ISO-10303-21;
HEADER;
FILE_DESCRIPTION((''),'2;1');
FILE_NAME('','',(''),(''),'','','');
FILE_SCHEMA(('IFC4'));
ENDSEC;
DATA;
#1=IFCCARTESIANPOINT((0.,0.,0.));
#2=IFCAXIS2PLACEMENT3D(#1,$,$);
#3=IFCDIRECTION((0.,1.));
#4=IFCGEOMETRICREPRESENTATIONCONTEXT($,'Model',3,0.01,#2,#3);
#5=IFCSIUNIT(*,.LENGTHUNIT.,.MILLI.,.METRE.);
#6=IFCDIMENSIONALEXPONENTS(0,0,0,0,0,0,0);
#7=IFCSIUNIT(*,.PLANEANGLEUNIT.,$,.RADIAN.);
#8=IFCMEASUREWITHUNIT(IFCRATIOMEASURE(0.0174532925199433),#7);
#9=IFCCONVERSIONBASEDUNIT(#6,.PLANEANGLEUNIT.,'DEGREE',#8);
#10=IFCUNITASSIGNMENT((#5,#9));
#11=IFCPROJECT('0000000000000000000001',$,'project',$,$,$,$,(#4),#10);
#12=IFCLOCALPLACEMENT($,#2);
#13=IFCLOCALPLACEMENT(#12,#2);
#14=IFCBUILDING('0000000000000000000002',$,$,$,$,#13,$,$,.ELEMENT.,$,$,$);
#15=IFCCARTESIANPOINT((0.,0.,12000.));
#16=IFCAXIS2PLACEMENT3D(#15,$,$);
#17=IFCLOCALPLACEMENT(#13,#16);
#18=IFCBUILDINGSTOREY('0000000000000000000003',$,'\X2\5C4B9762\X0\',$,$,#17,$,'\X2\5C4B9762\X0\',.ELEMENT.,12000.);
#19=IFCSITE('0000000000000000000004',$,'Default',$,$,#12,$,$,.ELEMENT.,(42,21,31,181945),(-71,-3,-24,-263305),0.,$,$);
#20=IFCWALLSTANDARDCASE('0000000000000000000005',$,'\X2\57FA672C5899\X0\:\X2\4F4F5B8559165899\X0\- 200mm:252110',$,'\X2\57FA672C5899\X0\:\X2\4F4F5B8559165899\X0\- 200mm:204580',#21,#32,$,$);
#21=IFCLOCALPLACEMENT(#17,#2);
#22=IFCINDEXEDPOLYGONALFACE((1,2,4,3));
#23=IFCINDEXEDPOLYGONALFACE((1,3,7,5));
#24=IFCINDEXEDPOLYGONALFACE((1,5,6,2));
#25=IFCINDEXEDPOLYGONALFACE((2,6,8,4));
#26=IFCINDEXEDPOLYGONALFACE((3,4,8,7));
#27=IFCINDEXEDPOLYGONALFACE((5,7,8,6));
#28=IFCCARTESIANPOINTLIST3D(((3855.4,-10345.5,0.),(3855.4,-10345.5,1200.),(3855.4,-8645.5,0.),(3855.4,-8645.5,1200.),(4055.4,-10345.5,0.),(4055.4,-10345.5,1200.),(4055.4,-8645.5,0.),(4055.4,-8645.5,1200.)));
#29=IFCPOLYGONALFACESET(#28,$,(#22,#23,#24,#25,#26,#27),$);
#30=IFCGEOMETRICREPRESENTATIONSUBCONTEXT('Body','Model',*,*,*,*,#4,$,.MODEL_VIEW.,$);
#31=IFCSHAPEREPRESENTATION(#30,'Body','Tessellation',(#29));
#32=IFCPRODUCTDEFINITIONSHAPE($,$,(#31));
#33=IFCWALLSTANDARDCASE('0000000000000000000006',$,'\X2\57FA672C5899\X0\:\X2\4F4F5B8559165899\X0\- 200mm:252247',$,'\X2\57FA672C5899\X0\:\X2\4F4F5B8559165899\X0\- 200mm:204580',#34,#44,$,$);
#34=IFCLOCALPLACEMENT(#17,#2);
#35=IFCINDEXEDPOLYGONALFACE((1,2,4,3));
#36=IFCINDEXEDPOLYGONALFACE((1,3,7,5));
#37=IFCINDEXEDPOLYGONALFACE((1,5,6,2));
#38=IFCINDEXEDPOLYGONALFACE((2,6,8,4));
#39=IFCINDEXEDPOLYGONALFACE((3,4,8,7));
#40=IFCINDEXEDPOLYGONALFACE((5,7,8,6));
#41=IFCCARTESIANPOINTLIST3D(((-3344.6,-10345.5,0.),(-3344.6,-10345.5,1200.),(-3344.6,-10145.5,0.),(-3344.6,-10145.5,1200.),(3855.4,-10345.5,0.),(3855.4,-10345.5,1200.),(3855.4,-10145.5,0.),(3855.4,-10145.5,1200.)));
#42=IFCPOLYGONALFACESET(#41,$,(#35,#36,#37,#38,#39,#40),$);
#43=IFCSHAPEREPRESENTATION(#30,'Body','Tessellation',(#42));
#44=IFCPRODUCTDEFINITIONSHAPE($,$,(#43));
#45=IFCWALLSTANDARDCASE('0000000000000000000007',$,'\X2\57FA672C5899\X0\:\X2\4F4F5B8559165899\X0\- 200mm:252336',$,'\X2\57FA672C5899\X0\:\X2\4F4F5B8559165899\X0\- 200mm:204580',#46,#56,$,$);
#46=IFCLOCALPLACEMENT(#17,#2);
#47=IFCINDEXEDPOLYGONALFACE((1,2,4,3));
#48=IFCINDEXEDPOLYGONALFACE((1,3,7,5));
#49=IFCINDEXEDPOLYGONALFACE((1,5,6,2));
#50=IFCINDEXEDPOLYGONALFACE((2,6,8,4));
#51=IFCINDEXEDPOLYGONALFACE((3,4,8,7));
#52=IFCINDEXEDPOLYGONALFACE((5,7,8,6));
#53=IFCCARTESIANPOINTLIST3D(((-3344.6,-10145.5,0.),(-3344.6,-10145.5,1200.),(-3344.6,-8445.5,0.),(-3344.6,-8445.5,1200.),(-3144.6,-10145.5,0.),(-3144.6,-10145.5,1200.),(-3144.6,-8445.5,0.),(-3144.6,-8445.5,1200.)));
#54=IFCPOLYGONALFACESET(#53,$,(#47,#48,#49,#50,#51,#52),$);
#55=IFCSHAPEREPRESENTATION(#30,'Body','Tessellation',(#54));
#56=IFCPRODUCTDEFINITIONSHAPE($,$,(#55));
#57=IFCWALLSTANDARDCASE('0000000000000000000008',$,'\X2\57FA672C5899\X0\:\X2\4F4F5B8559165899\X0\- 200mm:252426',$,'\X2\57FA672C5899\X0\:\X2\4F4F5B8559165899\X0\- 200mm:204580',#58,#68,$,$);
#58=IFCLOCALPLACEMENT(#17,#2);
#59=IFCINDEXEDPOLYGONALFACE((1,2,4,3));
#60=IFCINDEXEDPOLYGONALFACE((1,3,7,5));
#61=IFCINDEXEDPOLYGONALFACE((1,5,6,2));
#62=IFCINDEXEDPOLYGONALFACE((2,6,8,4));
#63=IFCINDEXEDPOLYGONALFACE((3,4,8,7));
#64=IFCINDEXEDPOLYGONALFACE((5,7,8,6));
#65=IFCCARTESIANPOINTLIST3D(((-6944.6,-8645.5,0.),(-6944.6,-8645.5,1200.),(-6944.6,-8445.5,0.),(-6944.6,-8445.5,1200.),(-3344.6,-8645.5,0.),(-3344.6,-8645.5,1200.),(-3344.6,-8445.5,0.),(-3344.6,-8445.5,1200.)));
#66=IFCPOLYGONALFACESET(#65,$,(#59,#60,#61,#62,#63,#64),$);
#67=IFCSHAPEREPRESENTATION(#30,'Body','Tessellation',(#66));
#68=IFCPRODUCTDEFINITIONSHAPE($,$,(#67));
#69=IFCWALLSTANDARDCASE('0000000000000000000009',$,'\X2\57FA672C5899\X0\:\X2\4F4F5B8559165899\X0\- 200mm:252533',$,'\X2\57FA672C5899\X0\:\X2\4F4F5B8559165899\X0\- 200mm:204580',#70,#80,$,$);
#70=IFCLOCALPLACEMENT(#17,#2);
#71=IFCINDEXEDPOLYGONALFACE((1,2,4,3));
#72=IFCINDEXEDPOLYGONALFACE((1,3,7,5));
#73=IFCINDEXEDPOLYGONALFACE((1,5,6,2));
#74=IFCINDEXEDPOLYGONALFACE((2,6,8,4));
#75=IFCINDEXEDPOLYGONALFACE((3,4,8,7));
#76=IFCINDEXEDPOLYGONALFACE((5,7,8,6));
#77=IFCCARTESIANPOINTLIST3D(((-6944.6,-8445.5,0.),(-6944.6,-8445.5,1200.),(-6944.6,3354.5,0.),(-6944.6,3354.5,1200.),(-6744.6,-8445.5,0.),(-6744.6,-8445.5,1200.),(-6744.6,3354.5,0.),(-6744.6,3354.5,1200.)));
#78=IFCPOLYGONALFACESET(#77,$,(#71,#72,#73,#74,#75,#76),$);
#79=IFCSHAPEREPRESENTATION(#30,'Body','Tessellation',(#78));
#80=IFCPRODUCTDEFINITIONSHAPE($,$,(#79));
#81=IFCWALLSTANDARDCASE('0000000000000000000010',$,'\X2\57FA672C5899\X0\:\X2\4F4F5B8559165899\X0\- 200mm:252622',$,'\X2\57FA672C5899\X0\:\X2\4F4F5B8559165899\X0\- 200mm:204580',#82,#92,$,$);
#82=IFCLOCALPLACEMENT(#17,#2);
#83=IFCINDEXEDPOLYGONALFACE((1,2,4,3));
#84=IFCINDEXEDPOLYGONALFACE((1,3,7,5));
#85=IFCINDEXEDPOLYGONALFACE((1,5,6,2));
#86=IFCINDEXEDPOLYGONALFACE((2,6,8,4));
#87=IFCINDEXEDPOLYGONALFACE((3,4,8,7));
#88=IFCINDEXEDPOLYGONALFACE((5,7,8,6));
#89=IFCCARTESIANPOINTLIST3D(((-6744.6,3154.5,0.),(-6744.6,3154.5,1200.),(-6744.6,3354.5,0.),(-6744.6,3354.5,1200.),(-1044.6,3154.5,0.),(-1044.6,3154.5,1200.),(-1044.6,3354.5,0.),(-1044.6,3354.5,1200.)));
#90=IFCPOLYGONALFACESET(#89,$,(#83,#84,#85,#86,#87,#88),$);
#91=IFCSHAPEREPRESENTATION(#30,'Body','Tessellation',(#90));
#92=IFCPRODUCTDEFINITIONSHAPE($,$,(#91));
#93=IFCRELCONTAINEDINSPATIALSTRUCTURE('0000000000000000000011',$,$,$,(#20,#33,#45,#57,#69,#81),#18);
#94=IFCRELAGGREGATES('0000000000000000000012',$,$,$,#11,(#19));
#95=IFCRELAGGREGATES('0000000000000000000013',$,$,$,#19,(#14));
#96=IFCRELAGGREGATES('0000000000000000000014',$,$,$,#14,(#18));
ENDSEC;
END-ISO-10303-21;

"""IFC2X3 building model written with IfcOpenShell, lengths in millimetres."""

from ifc_helpers import new_model, entity, si_unit, converted_unit, direction, frame, frame_2d, origin, place, context, subcontext, project, spatial, rectangle, extrude, element, save


model = new_model("IFC2X3")

# Units and contexts
model_context = context("Model", 3, precision=0.01, world=origin(), true_north=direction((0.0, 1.0)))
body_context = subcontext(model_context, "Body", "Model", "MODEL_VIEW")
ifc_project = project(units=[si_unit("LENGTHUNIT", "METRE", prefix="MILLI"), converted_unit("PLANEANGLEUNIT", "DEGREE", entity("IfcRatioMeasure", 0.0174532925199433), si_unit("PLANEANGLEUNIT", "RADIAN"), dimensions=[0, 0, 0, 0, 0, 0, 0])], contexts=[model_context])

# Site, building, storey
site_placement = place(None, origin())
site = spatial("IfcSite", under=ifc_project, at=site_placement, Name="Default", CompositionType="ELEMENT", RefLatitude=(42, 21, 31, 181945), RefLongitude=(-71, -3, -24, -263305), RefElevation=0.0)
building_placement = place(site_placement, origin())
building = spatial("IfcBuilding", under=site, at=building_placement, CompositionType="ELEMENT")
storey_placement = place(building_placement, frame((0.0, 0.0, 12000.0)))
storey = spatial("IfcBuildingStorey", under=building, at=storey_placement, Name="屋面", LongName="屋面", CompositionType="ELEMENT", Elevation=12000.0)

# Walls
wall_1_placement = place(storey_placement, frame((3955.4, -8645.5, 0.0), z_axis=(0.0, 0.0, 1.0), x_axis=(0.0, -1.0, 0.0)))
element("IfcWallStandardCase", 1, at=wall_1_placement, inside=storey, Name="基本墙:住宅外墙- 200mm:252110", ObjectType="基本墙:住宅外墙- 200mm:204580", context=body_context, shape_type="SweptSolid", body=[
    extrude(rectangle(XDim=1700.0, YDim=200.0, at=frame_2d((850.0, 0.0), x_axis=(-1.0, 0.0))), origin(), (0.0, 0.0, 1.0), 1200.0),
])
wall_2_placement = place(storey_placement, frame((3855.4, -10245.5, 0.0), z_axis=(0.0, 0.0, 1.0), x_axis=(-1.0, 0.0, 0.0)))
element("IfcWallStandardCase", 2, at=wall_2_placement, inside=storey, Name="基本墙:住宅外墙- 200mm:252247", ObjectType="基本墙:住宅外墙- 200mm:204580", context=body_context, shape_type="SweptSolid", body=[
    extrude(rectangle(XDim=7200.0, YDim=200.0, at=frame_2d((3600.0, 0.0), x_axis=(-1.0, 0.0))), origin(), (0.0, 0.0, 1.0), 1200.0),
])
wall_3_placement = place(storey_placement, frame((-3244.6, -10145.5, 0.0), z_axis=(0.0, 0.0, 1.0), x_axis=(0.0, 1.0, 0.0)))
element("IfcWallStandardCase", 3, at=wall_3_placement, inside=storey, Name="基本墙:住宅外墙- 200mm:252336", ObjectType="基本墙:住宅外墙- 200mm:204580", context=body_context, shape_type="SweptSolid", body=[
    extrude(rectangle(XDim=1700.0, YDim=200.0, at=frame_2d((850.0, 0.0), x_axis=(-1.0, 0.0))), origin(), (0.0, 0.0, 1.0), 1200.0),
])
wall_4_placement = place(storey_placement, frame((-3344.6, -8545.5, 0.0), z_axis=(0.0, 0.0, 1.0), x_axis=(-1.0, 0.0, 0.0)))
element("IfcWallStandardCase", 4, at=wall_4_placement, inside=storey, Name="基本墙:住宅外墙- 200mm:252426", ObjectType="基本墙:住宅外墙- 200mm:204580", context=body_context, shape_type="SweptSolid", body=[
    extrude(rectangle(XDim=3600.0, YDim=200.0, at=frame_2d((1800.0, 0.0), x_axis=(-1.0, 0.0))), origin(), (0.0, 0.0, 1.0), 1200.0),
])
wall_5_placement = place(storey_placement, frame((-6844.6, -8445.5, 0.0), z_axis=(0.0, 0.0, 1.0), x_axis=(0.0, 1.0, 0.0)))
element("IfcWallStandardCase", 5, at=wall_5_placement, inside=storey, Name="基本墙:住宅外墙- 200mm:252533", ObjectType="基本墙:住宅外墙- 200mm:204580", context=body_context, shape_type="SweptSolid", body=[
    extrude(rectangle(XDim=11800.0, YDim=200.0, at=frame_2d((5900.0, 0.0), x_axis=(-1.0, 0.0))), origin(), (0.0, 0.0, 1.0), 1200.0),
])
wall_6_placement = place(storey_placement, frame((-6744.6, 3254.5, 0.0)))
element("IfcWallStandardCase", 6, at=wall_6_placement, inside=storey, Name="基本墙:住宅外墙- 200mm:252622", ObjectType="基本墙:住宅外墙- 200mm:204580", context=body_context, shape_type="SweptSolid", body=[
    extrude(rectangle(XDim=5700.0, YDim=200.0, at=frame_2d((2850.0, 0.0), x_axis=(-1.0, 0.0))), origin(), (0.0, 0.0, 1.0), 1200.0),
])

save(model, "model.ifc")
